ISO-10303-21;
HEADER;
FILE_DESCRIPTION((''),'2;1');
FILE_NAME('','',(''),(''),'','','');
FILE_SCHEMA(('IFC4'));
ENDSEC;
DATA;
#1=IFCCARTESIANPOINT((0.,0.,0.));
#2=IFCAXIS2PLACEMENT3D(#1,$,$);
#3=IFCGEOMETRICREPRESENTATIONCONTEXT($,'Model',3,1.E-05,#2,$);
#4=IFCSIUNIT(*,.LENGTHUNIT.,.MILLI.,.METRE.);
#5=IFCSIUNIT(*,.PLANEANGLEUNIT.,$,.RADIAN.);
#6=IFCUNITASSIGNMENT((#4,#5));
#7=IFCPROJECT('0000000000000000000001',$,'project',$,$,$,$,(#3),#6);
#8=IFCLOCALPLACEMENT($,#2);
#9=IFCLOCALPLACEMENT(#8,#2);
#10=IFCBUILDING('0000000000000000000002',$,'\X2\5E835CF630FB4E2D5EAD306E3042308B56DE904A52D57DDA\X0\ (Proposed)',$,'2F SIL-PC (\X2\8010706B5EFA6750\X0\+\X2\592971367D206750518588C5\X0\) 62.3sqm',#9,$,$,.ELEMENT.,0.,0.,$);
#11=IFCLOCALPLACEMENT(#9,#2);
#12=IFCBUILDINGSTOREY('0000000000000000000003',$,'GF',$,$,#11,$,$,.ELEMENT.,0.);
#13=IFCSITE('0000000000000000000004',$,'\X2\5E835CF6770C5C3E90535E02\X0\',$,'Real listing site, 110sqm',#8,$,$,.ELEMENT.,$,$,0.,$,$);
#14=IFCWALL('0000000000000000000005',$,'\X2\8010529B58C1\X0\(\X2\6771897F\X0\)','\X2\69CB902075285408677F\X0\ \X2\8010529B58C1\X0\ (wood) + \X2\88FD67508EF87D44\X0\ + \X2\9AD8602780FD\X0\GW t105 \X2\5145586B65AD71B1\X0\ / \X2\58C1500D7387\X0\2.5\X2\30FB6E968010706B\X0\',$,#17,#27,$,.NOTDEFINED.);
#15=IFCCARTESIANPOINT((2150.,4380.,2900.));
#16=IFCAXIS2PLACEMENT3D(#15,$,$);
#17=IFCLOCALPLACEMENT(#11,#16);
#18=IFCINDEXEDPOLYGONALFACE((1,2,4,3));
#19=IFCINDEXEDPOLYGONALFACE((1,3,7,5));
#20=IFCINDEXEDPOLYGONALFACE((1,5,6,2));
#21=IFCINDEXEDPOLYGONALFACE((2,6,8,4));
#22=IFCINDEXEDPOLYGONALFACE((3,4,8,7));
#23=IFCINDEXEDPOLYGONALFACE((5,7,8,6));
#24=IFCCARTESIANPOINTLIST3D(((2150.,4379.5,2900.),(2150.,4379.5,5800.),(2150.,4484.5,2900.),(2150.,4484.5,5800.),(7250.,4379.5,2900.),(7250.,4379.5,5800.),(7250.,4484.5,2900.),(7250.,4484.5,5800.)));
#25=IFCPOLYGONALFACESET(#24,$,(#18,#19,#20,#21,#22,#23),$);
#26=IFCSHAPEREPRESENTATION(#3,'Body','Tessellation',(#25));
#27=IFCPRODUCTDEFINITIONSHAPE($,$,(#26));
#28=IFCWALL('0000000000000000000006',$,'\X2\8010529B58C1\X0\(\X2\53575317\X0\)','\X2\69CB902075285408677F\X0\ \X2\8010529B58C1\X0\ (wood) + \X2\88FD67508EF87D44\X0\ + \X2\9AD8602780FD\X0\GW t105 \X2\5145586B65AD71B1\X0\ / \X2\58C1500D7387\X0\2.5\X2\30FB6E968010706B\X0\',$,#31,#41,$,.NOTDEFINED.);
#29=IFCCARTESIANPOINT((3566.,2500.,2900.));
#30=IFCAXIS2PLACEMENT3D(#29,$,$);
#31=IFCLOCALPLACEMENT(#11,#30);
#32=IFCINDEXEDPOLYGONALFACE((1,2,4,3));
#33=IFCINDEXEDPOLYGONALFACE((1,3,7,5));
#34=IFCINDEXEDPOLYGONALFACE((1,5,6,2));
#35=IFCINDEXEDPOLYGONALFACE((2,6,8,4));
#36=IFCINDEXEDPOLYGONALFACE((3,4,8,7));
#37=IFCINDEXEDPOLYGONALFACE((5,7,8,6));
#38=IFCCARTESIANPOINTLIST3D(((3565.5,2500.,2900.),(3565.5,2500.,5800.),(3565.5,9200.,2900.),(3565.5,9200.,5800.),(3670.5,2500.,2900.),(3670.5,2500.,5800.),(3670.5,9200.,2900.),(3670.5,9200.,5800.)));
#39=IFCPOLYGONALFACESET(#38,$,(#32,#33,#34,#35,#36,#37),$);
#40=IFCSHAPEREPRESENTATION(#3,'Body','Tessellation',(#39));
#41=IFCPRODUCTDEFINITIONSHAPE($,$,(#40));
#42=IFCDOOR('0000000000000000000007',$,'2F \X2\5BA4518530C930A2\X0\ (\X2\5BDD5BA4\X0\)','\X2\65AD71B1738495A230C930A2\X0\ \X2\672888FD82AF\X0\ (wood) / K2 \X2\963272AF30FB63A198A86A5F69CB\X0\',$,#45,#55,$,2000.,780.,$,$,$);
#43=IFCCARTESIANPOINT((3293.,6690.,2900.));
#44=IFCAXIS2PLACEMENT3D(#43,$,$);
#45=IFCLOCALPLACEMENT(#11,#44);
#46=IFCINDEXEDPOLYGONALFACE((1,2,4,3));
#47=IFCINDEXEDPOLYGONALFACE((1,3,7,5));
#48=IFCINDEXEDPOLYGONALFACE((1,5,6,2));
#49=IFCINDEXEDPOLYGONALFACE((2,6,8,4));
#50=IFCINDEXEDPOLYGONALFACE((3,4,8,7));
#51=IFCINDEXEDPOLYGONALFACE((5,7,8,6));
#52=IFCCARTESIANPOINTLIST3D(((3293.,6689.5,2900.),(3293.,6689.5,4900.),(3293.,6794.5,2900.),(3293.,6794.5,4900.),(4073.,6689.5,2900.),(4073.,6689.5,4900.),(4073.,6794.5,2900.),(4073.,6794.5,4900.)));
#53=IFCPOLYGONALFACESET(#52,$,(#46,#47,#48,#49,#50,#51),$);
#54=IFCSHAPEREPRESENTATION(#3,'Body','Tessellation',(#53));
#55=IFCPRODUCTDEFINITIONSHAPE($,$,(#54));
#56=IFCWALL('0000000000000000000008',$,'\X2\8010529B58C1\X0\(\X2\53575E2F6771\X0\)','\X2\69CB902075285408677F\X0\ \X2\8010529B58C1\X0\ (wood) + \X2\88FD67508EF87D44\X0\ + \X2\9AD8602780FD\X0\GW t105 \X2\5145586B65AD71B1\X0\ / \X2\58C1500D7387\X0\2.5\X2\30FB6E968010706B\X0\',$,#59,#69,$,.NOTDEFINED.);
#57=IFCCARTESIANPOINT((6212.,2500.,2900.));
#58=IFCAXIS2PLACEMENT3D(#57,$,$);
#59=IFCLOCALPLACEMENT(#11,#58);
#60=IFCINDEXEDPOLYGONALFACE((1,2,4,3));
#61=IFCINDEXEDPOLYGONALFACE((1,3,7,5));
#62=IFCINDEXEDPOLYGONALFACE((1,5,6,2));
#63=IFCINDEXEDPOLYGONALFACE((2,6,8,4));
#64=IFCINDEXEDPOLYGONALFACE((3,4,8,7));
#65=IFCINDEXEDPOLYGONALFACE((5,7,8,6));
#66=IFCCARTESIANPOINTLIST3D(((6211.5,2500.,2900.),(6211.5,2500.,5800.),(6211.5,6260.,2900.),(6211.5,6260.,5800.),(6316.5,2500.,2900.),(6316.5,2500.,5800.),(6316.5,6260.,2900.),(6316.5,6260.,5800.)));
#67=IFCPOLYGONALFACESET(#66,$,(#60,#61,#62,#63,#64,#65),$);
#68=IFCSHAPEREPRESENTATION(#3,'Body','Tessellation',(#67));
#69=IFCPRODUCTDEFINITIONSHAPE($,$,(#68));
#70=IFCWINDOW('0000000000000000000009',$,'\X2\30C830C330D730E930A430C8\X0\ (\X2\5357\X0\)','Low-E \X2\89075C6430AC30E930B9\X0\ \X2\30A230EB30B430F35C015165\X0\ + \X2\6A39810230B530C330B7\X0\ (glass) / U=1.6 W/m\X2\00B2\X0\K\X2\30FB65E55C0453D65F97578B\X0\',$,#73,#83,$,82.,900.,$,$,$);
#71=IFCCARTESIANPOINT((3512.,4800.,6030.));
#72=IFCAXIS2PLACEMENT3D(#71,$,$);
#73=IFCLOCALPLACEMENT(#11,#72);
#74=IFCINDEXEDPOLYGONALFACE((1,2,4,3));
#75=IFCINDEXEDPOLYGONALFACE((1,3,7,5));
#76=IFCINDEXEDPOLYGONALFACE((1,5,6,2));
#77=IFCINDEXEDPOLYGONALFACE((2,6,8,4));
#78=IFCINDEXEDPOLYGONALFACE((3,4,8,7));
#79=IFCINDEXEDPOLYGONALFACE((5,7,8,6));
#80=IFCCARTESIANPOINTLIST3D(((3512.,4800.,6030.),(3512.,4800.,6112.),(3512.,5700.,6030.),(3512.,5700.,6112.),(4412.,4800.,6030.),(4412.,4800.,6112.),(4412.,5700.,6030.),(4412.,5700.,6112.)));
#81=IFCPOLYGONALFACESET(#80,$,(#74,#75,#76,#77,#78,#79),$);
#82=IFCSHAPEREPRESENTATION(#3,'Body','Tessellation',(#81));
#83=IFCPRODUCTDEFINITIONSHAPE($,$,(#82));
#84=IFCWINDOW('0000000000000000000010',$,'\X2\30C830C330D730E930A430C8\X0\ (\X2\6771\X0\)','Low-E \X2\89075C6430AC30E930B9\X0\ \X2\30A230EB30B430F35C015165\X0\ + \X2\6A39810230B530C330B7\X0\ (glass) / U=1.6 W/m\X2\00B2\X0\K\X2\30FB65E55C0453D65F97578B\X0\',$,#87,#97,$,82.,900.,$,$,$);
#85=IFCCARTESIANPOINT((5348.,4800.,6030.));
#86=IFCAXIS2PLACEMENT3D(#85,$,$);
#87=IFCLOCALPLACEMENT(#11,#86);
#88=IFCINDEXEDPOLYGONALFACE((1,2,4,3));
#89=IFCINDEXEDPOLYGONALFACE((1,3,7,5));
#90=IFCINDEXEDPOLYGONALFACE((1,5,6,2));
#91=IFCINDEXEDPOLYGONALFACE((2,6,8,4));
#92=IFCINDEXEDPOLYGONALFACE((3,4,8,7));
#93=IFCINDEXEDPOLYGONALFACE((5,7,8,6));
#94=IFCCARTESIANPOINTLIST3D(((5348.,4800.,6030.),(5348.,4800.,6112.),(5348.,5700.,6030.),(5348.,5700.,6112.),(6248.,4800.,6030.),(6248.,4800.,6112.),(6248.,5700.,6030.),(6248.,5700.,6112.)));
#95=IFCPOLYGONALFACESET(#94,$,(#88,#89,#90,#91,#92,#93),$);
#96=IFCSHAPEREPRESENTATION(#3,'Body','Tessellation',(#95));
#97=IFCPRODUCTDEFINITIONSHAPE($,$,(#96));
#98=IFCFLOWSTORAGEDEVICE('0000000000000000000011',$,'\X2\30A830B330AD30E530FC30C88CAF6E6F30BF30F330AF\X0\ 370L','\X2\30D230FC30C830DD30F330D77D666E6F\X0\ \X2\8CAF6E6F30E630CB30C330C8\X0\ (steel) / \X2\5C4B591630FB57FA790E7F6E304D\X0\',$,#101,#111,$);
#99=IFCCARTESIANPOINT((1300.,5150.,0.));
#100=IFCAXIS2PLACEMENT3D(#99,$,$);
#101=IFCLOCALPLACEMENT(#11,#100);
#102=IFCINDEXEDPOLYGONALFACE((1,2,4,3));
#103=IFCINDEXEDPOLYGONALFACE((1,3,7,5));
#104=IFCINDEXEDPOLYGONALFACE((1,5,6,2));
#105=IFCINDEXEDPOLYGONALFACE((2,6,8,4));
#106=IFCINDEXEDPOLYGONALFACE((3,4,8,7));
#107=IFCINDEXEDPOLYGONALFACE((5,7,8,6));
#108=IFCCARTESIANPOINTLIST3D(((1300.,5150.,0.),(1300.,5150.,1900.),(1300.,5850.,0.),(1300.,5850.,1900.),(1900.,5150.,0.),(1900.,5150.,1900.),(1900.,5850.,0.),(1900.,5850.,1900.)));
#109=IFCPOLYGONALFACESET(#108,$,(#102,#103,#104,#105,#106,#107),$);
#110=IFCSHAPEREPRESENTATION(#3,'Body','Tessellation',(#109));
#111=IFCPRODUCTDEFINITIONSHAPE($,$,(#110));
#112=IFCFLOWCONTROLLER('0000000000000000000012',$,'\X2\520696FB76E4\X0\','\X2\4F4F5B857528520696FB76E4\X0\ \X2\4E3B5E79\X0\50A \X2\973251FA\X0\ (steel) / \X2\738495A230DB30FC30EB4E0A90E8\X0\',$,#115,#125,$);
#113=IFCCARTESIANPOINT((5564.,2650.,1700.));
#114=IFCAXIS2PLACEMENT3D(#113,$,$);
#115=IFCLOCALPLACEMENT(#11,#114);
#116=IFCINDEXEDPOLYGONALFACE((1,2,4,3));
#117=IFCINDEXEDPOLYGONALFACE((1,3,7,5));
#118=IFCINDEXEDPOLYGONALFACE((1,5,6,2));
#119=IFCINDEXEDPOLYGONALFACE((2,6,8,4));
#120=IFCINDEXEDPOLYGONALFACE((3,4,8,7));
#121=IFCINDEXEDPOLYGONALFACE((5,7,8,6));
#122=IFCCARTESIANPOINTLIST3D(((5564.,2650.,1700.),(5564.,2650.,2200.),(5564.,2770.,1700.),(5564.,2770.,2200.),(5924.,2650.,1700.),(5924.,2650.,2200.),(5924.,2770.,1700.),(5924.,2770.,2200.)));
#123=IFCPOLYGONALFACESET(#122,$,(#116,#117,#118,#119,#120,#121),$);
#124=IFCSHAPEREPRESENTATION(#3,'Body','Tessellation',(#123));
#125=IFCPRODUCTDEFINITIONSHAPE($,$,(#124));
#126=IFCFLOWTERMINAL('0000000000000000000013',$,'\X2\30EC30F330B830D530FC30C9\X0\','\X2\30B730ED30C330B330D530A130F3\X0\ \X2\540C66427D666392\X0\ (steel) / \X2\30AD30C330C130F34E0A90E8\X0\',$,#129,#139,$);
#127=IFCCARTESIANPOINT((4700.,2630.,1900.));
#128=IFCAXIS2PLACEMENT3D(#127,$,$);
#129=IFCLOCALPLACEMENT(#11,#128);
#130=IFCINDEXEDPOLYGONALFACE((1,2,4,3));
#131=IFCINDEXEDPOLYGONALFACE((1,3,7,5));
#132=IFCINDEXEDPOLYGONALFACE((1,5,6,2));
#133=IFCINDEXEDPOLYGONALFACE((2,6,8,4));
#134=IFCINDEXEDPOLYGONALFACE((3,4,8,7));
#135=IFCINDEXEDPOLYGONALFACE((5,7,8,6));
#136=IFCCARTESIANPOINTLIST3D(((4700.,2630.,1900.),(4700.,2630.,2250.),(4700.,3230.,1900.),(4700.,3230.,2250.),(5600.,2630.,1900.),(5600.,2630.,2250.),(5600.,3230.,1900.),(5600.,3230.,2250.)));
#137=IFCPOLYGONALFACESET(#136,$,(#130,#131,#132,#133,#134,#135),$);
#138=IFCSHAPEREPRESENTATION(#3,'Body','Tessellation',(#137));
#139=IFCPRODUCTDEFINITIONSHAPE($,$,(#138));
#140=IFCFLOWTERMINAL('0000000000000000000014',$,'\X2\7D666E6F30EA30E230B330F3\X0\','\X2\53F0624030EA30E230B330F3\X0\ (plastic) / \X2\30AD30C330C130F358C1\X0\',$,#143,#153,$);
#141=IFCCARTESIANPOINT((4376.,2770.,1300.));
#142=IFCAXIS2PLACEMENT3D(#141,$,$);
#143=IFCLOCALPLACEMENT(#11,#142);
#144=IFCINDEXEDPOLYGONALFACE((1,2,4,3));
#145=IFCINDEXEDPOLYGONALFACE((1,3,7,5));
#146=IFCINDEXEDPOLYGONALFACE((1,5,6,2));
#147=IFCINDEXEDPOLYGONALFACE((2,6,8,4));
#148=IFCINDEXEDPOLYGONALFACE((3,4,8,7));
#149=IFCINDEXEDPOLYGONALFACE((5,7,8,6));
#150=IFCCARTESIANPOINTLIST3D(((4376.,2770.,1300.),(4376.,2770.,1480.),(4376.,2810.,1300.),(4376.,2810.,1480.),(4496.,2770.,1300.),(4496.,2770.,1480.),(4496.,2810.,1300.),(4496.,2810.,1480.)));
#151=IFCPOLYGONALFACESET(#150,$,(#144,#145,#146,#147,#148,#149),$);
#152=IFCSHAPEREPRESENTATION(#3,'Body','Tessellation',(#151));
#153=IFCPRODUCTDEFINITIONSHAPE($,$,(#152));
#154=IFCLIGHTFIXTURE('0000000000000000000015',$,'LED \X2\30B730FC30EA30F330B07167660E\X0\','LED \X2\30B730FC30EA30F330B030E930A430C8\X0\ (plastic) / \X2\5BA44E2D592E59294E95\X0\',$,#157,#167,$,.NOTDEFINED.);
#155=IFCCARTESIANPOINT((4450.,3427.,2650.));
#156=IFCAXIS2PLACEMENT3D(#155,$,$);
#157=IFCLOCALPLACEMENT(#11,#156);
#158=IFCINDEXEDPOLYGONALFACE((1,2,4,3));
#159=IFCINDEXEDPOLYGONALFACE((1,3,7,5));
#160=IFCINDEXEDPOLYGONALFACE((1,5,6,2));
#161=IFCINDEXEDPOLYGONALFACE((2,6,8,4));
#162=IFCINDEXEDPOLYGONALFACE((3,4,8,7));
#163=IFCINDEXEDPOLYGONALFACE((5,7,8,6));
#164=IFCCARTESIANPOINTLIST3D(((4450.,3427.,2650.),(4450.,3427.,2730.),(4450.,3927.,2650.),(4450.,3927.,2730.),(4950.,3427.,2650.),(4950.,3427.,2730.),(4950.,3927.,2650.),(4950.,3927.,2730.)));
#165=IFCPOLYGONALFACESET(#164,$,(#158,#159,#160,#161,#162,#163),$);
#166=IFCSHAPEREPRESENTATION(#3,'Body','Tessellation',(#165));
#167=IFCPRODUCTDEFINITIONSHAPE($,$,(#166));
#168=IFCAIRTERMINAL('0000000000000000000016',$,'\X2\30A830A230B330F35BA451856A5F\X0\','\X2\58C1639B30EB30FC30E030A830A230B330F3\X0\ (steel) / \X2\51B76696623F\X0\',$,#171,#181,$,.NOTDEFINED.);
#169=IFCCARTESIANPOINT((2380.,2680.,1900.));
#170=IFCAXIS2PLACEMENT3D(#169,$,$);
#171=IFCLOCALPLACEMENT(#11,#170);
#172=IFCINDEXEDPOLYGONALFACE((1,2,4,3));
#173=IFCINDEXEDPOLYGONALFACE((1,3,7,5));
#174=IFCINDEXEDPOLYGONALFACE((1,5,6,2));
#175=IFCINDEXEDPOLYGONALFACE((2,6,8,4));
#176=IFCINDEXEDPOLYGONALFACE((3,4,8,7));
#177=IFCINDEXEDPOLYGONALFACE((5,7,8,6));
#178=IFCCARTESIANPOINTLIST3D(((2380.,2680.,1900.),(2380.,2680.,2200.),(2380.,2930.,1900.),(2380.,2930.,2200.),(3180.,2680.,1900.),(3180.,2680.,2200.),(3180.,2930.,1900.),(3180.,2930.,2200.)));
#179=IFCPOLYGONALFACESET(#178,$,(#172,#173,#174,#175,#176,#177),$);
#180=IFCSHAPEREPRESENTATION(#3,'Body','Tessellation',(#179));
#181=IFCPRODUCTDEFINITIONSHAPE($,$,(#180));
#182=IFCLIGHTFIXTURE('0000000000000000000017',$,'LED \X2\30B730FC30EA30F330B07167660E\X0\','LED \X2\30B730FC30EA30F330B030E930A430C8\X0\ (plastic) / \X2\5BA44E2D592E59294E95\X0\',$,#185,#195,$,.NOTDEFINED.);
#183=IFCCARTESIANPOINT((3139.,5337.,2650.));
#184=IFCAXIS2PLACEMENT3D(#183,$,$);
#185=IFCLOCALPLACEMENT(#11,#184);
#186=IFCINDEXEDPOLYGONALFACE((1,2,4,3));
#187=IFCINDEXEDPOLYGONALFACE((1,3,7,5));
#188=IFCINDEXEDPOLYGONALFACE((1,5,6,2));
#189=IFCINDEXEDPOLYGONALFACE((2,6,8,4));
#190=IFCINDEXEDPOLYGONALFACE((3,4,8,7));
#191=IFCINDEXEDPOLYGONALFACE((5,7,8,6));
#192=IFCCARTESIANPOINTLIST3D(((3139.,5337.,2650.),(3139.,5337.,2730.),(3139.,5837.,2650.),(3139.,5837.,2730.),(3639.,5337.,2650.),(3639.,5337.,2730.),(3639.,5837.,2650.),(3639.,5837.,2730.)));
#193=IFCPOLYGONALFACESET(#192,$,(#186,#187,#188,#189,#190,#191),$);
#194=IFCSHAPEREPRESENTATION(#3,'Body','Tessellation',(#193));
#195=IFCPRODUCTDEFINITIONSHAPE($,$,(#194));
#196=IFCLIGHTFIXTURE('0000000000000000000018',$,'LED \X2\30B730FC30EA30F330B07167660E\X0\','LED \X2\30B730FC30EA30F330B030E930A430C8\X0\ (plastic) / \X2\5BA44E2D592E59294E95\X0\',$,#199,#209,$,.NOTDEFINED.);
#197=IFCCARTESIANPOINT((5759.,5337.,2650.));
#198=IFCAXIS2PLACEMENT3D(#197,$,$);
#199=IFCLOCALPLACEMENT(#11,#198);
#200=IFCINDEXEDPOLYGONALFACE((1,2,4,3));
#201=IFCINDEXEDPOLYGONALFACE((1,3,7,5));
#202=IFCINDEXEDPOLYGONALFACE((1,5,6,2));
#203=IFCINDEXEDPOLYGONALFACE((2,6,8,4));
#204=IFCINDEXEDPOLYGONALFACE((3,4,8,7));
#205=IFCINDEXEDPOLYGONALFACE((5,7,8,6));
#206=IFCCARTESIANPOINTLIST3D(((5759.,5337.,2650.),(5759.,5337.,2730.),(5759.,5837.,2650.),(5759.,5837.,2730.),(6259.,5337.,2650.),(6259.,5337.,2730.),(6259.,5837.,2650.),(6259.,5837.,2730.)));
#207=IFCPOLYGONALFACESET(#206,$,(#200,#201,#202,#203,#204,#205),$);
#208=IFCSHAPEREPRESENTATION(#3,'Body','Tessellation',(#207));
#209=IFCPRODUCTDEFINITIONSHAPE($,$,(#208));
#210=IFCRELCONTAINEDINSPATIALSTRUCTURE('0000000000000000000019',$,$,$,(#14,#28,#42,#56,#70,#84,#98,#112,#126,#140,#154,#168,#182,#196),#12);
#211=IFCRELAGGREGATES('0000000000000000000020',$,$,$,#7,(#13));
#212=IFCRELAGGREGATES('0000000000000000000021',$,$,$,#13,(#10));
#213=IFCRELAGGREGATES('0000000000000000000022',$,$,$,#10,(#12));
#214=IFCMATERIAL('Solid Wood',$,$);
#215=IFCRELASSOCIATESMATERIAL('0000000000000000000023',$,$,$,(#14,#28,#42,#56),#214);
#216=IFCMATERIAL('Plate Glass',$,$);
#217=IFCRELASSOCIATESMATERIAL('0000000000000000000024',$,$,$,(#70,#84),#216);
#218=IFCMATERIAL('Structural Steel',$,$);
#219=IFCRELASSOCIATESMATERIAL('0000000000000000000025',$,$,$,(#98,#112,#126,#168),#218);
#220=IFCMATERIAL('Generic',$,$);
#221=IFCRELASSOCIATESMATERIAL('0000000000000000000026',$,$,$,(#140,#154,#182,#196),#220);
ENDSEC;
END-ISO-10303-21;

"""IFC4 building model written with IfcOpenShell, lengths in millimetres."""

from ifc_helpers import new_model, si_unit, frame, frame_2d, origin, place, context, project, spatial, rectangle, extrude, material, element, fill, save


model = new_model("IFC4")

# Units and contexts
model_context = context("Model", 3, precision=1e-05, world=origin())
ifc_project = project(units=[si_unit("LENGTHUNIT", "METRE", prefix="MILLI"), si_unit("PLANEANGLEUNIT", "RADIAN")], contexts=[model_context])

# Site, building, storey
site_placement = place(None, origin())
site = spatial("IfcSite", under=ifc_project, at=site_placement, Name="広島県尾道市", ObjectType="Real listing site, 110sqm", CompositionType="ELEMENT", RefElevation=0.0)
building_placement = place(site_placement, origin())
building = spatial("IfcBuilding", under=site, at=building_placement, Name="広島・中庭のある回遊動線 (Proposed)", ObjectType="2F SIL-PC (耐火建材+天然素材内装) 62.3sqm", CompositionType="ELEMENT", ElevationOfRefHeight=0.0, ElevationOfTerrain=0.0)
storey_placement = place(building_placement, origin())
storey = spatial("IfcBuildingStorey", under=building, at=storey_placement, Name="GF", CompositionType="ELEMENT", Elevation=0.0)

# Shared definitions
ifc_material_1 = material(Name="Solid Wood")

# Wall
wall_1_placement = place(storey_placement, frame((2150.0, 4380.0, 2900.0)))
element("IfcWall", 1, at=wall_1_placement, inside=storey, material=ifc_material_1, Name="耐力壁(東西)", Description="構造用合板 耐力壁 (wood) + 製材軸組 + 高性能GW t105 充填断熱 / 壁倍率2.5・準耐火", PredefinedType="NOTDEFINED", context=model_context, shape_type="SweptSolid", body=[
    extrude(rectangle(XDim=5100.0, YDim=105.0, at=frame_2d((2550.0, 52.0))), frame((2150.0, 4380.0, 2900.0)), (0.0, 0.0, 1.0), 2900.0),
])

# Wall, opening, door
wall_2_placement = place(storey_placement, frame((3566.0, 2500.0, 2900.0)))
wall_2 = element("IfcWall", 2, at=wall_2_placement, inside=storey, material=ifc_material_1, Name="耐力壁(南北)", Description="構造用合板 耐力壁 (wood) + 製材軸組 + 高性能GW t105 充填断熱 / 壁倍率2.5・準耐火", PredefinedType="NOTDEFINED", context=model_context, shape_type="SweptSolid", body=[
    extrude(rectangle(XDim=105.0, YDim=6700.0, at=frame_2d((52.0, 3350.0))), frame((3566.0, 2500.0, 2900.0)), (0.0, 0.0, 1.0), 2900.0),
])
opening_placement = place(storey_placement, frame((3293.0, 6690.0, 2900.0)))
opening = element("IfcOpeningElement", 3, at=opening_placement, cuts=wall_2, PredefinedType="NOTDEFINED", context=model_context, shape_type="SweptSolid", body=[
    extrude(rectangle(XDim=780.0, YDim=105.0, at=frame_2d((390.0, 52.0))), frame((3293.0, 6690.0, 2900.0)), (0.0, 0.0, 1.0), 2000.0),
])
door_placement = place(storey_placement, frame((3293.0, 6690.0, 2900.0)))
door = element("IfcDoor", 4, at=door_placement, inside=storey, material=ifc_material_1, Name="2F 室内ドア (寝室)", Description="断熱玄関ドア 木製芯 (wood) / K2 防犯・採風機構", OverallHeight=2000.0, OverallWidth=780.0, context=model_context, shape_type="SweptSolid", body=[
    extrude(rectangle(XDim=780.0, YDim=105.0, at=frame_2d((390.0, 52.0))), frame((3293.0, 6690.0, 2900.0)), (0.0, 0.0, 1.0), 2000.0),
])
fill(opening, door)

# Wall
wall_3_placement = place(storey_placement, frame((6212.0, 2500.0, 2900.0)))
element("IfcWall", 5, at=wall_3_placement, inside=storey, material=ifc_material_1, Name="耐力壁(南帯東)", Description="構造用合板 耐力壁 (wood) + 製材軸組 + 高性能GW t105 充填断熱 / 壁倍率2.5・準耐火", PredefinedType="NOTDEFINED", context=model_context, shape_type="SweptSolid", body=[
    extrude(rectangle(XDim=105.0, YDim=3760.0, at=frame_2d((52.0, 1880.0))), frame((6212.0, 2500.0, 2900.0)), (0.0, 0.0, 1.0), 2900.0),
])

# Windows
ifc_material_2 = material(Name="Plate Glass")
window_1_placement = place(storey_placement, frame((3512.0, 4800.0, 6030.0)))
element("IfcWindow", 6, at=window_1_placement, inside=storey, material=ifc_material_2, Name="トップライト (南)", Description="Low-E 複層ガラス アルゴン封入 + 樹脂サッシ (glass) / U=1.6 W/m²K・日射取得型", OverallHeight=82.0, OverallWidth=900.0, context=model_context, shape_type="SweptSolid", body=[
    extrude(rectangle(XDim=900.0, YDim=900.0, at=frame_2d((450.0, 450.0))), frame((3512.0, 4800.0, 6030.0)), (0.0, 0.0, 1.0), 82.0),
])
window_2_placement = place(storey_placement, frame((5348.0, 4800.0, 6030.0)))
element("IfcWindow", 7, at=window_2_placement, inside=storey, material=ifc_material_2, Name="トップライト (東)", Description="Low-E 複層ガラス アルゴン封入 + 樹脂サッシ (glass) / U=1.6 W/m²K・日射取得型", OverallHeight=82.0, OverallWidth=900.0, context=model_context, shape_type="SweptSolid", body=[
    extrude(rectangle(XDim=900.0, YDim=900.0, at=frame_2d((450.0, 450.0))), frame((5348.0, 4800.0, 6030.0)), (0.0, 0.0, 1.0), 82.0),
])

# Flow storage device
ifc_material_3 = material(Name="Structural Steel")
flow_storage_device_placement = place(storey_placement, frame((1300.0, 5150.0, 0.0)))
element("IfcFlowStorageDevice", 8, at=flow_storage_device_placement, inside=storey, material=ifc_material_3, Name="エコキュート貯湯タンク 370L", Description="ヒートポンプ給湯 貯湯ユニット (steel) / 屋外・基礎置き", context=model_context, shape_type="SweptSolid", body=[
    extrude(rectangle(XDim=600.0, YDim=700.0, at=frame_2d((300.0, 350.0))), frame((1300.0, 5150.0, 0.0)), (0.0, 0.0, 1.0), 1900.0),
])

# Flow controller
flow_controller_placement = place(storey_placement, frame((5564.0, 2650.0, 1700.0)))
element("IfcFlowController", 9, at=flow_controller_placement, inside=storey, material=ifc_material_3, Name="分電盤", Description="住宅用分電盤 主幹50A 露出 (steel) / 玄関ホール上部", context=model_context, shape_type="SweptSolid", body=[
    extrude(rectangle(XDim=360.0, YDim=120.0, at=frame_2d((180.0, 60.0))), frame((5564.0, 2650.0, 1700.0)), (0.0, 0.0, 1.0), 500.0),
])

# Flow terminals
flow_terminal_1_placement = place(storey_placement, frame((4700.0, 2630.0, 1900.0)))
element("IfcFlowTerminal", 10, at=flow_terminal_1_placement, inside=storey, material=ifc_material_3, Name="レンジフード", Description="シロッコファン 同時給排 (steel) / キッチン上部", context=model_context, shape_type="SweptSolid", body=[
    extrude(rectangle(XDim=900.0, YDim=600.0, at=frame_2d((450.0, 300.0))), frame((4700.0, 2630.0, 1900.0)), (0.0, 0.0, 1.0), 350.0),
])
ifc_material_4 = material(Name="Generic")
flow_terminal_2_placement = place(storey_placement, frame((4376.0, 2770.0, 1300.0)))
element("IfcFlowTerminal", 11, at=flow_terminal_2_placement, inside=storey, material=ifc_material_4, Name="給湯リモコン", Description="台所リモコン (plastic) / キッチン壁", context=model_context, shape_type="SweptSolid", body=[
    extrude(rectangle(XDim=120.0, YDim=40.0, at=frame_2d((60.0, 20.0))), frame((4376.0, 2770.0, 1300.0)), (0.0, 0.0, 1.0), 180.0),
])

# Light fixture
light_fixture_1_placement = place(storey_placement, frame((4450.0, 3427.0, 2650.0)))
element("IfcLightFixture", 12, at=light_fixture_1_placement, inside=storey, material=ifc_material_4, Name="LED シーリング照明", Description="LED シーリングライト (plastic) / 室中央天井", PredefinedType="NOTDEFINED", context=model_context, shape_type="SweptSolid", body=[
    extrude(rectangle(XDim=500.0, YDim=500.0, at=frame_2d((250.0, 250.0))), frame((4450.0, 3427.0, 2650.0)), (0.0, 0.0, 1.0), 80.0),
])

# Air terminal
air_terminal_1_placement = place(storey_placement, frame((2380.0, 2680.0, 1900.0)))
element("IfcAirTerminal", 13, at=air_terminal_1_placement, inside=storey, material=ifc_material_3, Name="エアコン室内機", Description="壁掛ルームエアコン (steel) / 冷暖房", PredefinedType="NOTDEFINED", context=model_context, shape_type="SweptSolid", body=[
    extrude(rectangle(XDim=800.0, YDim=250.0, at=frame_2d((400.0, 125.0))), frame((2380.0, 2680.0, 1900.0)), (0.0, 0.0, 1.0), 300.0),
])

# Light fixtures
light_fixture_2_placement = place(storey_placement, frame((3139.0, 5337.0, 2650.0)))
element("IfcLightFixture", 14, at=light_fixture_2_placement, inside=storey, material=ifc_material_4, Name="LED シーリング照明", Description="LED シーリングライト (plastic) / 室中央天井", PredefinedType="NOTDEFINED", context=model_context, shape_type="SweptSolid", body=[
    extrude(rectangle(XDim=500.0, YDim=500.0, at=frame_2d((250.0, 250.0))), frame((3139.0, 5337.0, 2650.0)), (0.0, 0.0, 1.0), 80.0),
])
light_fixture_3_placement = place(storey_placement, frame((5759.0, 5337.0, 2650.0)))
element("IfcLightFixture", 15, at=light_fixture_3_placement, inside=storey, material=ifc_material_4, Name="LED シーリング照明", Description="LED シーリングライト (plastic) / 室中央天井", PredefinedType="NOTDEFINED", context=model_context, shape_type="SweptSolid", body=[
    extrude(rectangle(XDim=500.0, YDim=500.0, at=frame_2d((250.0, 250.0))), frame((5759.0, 5337.0, 2650.0)), (0.0, 0.0, 1.0), 80.0),
])

save(model, "model.ifc")
